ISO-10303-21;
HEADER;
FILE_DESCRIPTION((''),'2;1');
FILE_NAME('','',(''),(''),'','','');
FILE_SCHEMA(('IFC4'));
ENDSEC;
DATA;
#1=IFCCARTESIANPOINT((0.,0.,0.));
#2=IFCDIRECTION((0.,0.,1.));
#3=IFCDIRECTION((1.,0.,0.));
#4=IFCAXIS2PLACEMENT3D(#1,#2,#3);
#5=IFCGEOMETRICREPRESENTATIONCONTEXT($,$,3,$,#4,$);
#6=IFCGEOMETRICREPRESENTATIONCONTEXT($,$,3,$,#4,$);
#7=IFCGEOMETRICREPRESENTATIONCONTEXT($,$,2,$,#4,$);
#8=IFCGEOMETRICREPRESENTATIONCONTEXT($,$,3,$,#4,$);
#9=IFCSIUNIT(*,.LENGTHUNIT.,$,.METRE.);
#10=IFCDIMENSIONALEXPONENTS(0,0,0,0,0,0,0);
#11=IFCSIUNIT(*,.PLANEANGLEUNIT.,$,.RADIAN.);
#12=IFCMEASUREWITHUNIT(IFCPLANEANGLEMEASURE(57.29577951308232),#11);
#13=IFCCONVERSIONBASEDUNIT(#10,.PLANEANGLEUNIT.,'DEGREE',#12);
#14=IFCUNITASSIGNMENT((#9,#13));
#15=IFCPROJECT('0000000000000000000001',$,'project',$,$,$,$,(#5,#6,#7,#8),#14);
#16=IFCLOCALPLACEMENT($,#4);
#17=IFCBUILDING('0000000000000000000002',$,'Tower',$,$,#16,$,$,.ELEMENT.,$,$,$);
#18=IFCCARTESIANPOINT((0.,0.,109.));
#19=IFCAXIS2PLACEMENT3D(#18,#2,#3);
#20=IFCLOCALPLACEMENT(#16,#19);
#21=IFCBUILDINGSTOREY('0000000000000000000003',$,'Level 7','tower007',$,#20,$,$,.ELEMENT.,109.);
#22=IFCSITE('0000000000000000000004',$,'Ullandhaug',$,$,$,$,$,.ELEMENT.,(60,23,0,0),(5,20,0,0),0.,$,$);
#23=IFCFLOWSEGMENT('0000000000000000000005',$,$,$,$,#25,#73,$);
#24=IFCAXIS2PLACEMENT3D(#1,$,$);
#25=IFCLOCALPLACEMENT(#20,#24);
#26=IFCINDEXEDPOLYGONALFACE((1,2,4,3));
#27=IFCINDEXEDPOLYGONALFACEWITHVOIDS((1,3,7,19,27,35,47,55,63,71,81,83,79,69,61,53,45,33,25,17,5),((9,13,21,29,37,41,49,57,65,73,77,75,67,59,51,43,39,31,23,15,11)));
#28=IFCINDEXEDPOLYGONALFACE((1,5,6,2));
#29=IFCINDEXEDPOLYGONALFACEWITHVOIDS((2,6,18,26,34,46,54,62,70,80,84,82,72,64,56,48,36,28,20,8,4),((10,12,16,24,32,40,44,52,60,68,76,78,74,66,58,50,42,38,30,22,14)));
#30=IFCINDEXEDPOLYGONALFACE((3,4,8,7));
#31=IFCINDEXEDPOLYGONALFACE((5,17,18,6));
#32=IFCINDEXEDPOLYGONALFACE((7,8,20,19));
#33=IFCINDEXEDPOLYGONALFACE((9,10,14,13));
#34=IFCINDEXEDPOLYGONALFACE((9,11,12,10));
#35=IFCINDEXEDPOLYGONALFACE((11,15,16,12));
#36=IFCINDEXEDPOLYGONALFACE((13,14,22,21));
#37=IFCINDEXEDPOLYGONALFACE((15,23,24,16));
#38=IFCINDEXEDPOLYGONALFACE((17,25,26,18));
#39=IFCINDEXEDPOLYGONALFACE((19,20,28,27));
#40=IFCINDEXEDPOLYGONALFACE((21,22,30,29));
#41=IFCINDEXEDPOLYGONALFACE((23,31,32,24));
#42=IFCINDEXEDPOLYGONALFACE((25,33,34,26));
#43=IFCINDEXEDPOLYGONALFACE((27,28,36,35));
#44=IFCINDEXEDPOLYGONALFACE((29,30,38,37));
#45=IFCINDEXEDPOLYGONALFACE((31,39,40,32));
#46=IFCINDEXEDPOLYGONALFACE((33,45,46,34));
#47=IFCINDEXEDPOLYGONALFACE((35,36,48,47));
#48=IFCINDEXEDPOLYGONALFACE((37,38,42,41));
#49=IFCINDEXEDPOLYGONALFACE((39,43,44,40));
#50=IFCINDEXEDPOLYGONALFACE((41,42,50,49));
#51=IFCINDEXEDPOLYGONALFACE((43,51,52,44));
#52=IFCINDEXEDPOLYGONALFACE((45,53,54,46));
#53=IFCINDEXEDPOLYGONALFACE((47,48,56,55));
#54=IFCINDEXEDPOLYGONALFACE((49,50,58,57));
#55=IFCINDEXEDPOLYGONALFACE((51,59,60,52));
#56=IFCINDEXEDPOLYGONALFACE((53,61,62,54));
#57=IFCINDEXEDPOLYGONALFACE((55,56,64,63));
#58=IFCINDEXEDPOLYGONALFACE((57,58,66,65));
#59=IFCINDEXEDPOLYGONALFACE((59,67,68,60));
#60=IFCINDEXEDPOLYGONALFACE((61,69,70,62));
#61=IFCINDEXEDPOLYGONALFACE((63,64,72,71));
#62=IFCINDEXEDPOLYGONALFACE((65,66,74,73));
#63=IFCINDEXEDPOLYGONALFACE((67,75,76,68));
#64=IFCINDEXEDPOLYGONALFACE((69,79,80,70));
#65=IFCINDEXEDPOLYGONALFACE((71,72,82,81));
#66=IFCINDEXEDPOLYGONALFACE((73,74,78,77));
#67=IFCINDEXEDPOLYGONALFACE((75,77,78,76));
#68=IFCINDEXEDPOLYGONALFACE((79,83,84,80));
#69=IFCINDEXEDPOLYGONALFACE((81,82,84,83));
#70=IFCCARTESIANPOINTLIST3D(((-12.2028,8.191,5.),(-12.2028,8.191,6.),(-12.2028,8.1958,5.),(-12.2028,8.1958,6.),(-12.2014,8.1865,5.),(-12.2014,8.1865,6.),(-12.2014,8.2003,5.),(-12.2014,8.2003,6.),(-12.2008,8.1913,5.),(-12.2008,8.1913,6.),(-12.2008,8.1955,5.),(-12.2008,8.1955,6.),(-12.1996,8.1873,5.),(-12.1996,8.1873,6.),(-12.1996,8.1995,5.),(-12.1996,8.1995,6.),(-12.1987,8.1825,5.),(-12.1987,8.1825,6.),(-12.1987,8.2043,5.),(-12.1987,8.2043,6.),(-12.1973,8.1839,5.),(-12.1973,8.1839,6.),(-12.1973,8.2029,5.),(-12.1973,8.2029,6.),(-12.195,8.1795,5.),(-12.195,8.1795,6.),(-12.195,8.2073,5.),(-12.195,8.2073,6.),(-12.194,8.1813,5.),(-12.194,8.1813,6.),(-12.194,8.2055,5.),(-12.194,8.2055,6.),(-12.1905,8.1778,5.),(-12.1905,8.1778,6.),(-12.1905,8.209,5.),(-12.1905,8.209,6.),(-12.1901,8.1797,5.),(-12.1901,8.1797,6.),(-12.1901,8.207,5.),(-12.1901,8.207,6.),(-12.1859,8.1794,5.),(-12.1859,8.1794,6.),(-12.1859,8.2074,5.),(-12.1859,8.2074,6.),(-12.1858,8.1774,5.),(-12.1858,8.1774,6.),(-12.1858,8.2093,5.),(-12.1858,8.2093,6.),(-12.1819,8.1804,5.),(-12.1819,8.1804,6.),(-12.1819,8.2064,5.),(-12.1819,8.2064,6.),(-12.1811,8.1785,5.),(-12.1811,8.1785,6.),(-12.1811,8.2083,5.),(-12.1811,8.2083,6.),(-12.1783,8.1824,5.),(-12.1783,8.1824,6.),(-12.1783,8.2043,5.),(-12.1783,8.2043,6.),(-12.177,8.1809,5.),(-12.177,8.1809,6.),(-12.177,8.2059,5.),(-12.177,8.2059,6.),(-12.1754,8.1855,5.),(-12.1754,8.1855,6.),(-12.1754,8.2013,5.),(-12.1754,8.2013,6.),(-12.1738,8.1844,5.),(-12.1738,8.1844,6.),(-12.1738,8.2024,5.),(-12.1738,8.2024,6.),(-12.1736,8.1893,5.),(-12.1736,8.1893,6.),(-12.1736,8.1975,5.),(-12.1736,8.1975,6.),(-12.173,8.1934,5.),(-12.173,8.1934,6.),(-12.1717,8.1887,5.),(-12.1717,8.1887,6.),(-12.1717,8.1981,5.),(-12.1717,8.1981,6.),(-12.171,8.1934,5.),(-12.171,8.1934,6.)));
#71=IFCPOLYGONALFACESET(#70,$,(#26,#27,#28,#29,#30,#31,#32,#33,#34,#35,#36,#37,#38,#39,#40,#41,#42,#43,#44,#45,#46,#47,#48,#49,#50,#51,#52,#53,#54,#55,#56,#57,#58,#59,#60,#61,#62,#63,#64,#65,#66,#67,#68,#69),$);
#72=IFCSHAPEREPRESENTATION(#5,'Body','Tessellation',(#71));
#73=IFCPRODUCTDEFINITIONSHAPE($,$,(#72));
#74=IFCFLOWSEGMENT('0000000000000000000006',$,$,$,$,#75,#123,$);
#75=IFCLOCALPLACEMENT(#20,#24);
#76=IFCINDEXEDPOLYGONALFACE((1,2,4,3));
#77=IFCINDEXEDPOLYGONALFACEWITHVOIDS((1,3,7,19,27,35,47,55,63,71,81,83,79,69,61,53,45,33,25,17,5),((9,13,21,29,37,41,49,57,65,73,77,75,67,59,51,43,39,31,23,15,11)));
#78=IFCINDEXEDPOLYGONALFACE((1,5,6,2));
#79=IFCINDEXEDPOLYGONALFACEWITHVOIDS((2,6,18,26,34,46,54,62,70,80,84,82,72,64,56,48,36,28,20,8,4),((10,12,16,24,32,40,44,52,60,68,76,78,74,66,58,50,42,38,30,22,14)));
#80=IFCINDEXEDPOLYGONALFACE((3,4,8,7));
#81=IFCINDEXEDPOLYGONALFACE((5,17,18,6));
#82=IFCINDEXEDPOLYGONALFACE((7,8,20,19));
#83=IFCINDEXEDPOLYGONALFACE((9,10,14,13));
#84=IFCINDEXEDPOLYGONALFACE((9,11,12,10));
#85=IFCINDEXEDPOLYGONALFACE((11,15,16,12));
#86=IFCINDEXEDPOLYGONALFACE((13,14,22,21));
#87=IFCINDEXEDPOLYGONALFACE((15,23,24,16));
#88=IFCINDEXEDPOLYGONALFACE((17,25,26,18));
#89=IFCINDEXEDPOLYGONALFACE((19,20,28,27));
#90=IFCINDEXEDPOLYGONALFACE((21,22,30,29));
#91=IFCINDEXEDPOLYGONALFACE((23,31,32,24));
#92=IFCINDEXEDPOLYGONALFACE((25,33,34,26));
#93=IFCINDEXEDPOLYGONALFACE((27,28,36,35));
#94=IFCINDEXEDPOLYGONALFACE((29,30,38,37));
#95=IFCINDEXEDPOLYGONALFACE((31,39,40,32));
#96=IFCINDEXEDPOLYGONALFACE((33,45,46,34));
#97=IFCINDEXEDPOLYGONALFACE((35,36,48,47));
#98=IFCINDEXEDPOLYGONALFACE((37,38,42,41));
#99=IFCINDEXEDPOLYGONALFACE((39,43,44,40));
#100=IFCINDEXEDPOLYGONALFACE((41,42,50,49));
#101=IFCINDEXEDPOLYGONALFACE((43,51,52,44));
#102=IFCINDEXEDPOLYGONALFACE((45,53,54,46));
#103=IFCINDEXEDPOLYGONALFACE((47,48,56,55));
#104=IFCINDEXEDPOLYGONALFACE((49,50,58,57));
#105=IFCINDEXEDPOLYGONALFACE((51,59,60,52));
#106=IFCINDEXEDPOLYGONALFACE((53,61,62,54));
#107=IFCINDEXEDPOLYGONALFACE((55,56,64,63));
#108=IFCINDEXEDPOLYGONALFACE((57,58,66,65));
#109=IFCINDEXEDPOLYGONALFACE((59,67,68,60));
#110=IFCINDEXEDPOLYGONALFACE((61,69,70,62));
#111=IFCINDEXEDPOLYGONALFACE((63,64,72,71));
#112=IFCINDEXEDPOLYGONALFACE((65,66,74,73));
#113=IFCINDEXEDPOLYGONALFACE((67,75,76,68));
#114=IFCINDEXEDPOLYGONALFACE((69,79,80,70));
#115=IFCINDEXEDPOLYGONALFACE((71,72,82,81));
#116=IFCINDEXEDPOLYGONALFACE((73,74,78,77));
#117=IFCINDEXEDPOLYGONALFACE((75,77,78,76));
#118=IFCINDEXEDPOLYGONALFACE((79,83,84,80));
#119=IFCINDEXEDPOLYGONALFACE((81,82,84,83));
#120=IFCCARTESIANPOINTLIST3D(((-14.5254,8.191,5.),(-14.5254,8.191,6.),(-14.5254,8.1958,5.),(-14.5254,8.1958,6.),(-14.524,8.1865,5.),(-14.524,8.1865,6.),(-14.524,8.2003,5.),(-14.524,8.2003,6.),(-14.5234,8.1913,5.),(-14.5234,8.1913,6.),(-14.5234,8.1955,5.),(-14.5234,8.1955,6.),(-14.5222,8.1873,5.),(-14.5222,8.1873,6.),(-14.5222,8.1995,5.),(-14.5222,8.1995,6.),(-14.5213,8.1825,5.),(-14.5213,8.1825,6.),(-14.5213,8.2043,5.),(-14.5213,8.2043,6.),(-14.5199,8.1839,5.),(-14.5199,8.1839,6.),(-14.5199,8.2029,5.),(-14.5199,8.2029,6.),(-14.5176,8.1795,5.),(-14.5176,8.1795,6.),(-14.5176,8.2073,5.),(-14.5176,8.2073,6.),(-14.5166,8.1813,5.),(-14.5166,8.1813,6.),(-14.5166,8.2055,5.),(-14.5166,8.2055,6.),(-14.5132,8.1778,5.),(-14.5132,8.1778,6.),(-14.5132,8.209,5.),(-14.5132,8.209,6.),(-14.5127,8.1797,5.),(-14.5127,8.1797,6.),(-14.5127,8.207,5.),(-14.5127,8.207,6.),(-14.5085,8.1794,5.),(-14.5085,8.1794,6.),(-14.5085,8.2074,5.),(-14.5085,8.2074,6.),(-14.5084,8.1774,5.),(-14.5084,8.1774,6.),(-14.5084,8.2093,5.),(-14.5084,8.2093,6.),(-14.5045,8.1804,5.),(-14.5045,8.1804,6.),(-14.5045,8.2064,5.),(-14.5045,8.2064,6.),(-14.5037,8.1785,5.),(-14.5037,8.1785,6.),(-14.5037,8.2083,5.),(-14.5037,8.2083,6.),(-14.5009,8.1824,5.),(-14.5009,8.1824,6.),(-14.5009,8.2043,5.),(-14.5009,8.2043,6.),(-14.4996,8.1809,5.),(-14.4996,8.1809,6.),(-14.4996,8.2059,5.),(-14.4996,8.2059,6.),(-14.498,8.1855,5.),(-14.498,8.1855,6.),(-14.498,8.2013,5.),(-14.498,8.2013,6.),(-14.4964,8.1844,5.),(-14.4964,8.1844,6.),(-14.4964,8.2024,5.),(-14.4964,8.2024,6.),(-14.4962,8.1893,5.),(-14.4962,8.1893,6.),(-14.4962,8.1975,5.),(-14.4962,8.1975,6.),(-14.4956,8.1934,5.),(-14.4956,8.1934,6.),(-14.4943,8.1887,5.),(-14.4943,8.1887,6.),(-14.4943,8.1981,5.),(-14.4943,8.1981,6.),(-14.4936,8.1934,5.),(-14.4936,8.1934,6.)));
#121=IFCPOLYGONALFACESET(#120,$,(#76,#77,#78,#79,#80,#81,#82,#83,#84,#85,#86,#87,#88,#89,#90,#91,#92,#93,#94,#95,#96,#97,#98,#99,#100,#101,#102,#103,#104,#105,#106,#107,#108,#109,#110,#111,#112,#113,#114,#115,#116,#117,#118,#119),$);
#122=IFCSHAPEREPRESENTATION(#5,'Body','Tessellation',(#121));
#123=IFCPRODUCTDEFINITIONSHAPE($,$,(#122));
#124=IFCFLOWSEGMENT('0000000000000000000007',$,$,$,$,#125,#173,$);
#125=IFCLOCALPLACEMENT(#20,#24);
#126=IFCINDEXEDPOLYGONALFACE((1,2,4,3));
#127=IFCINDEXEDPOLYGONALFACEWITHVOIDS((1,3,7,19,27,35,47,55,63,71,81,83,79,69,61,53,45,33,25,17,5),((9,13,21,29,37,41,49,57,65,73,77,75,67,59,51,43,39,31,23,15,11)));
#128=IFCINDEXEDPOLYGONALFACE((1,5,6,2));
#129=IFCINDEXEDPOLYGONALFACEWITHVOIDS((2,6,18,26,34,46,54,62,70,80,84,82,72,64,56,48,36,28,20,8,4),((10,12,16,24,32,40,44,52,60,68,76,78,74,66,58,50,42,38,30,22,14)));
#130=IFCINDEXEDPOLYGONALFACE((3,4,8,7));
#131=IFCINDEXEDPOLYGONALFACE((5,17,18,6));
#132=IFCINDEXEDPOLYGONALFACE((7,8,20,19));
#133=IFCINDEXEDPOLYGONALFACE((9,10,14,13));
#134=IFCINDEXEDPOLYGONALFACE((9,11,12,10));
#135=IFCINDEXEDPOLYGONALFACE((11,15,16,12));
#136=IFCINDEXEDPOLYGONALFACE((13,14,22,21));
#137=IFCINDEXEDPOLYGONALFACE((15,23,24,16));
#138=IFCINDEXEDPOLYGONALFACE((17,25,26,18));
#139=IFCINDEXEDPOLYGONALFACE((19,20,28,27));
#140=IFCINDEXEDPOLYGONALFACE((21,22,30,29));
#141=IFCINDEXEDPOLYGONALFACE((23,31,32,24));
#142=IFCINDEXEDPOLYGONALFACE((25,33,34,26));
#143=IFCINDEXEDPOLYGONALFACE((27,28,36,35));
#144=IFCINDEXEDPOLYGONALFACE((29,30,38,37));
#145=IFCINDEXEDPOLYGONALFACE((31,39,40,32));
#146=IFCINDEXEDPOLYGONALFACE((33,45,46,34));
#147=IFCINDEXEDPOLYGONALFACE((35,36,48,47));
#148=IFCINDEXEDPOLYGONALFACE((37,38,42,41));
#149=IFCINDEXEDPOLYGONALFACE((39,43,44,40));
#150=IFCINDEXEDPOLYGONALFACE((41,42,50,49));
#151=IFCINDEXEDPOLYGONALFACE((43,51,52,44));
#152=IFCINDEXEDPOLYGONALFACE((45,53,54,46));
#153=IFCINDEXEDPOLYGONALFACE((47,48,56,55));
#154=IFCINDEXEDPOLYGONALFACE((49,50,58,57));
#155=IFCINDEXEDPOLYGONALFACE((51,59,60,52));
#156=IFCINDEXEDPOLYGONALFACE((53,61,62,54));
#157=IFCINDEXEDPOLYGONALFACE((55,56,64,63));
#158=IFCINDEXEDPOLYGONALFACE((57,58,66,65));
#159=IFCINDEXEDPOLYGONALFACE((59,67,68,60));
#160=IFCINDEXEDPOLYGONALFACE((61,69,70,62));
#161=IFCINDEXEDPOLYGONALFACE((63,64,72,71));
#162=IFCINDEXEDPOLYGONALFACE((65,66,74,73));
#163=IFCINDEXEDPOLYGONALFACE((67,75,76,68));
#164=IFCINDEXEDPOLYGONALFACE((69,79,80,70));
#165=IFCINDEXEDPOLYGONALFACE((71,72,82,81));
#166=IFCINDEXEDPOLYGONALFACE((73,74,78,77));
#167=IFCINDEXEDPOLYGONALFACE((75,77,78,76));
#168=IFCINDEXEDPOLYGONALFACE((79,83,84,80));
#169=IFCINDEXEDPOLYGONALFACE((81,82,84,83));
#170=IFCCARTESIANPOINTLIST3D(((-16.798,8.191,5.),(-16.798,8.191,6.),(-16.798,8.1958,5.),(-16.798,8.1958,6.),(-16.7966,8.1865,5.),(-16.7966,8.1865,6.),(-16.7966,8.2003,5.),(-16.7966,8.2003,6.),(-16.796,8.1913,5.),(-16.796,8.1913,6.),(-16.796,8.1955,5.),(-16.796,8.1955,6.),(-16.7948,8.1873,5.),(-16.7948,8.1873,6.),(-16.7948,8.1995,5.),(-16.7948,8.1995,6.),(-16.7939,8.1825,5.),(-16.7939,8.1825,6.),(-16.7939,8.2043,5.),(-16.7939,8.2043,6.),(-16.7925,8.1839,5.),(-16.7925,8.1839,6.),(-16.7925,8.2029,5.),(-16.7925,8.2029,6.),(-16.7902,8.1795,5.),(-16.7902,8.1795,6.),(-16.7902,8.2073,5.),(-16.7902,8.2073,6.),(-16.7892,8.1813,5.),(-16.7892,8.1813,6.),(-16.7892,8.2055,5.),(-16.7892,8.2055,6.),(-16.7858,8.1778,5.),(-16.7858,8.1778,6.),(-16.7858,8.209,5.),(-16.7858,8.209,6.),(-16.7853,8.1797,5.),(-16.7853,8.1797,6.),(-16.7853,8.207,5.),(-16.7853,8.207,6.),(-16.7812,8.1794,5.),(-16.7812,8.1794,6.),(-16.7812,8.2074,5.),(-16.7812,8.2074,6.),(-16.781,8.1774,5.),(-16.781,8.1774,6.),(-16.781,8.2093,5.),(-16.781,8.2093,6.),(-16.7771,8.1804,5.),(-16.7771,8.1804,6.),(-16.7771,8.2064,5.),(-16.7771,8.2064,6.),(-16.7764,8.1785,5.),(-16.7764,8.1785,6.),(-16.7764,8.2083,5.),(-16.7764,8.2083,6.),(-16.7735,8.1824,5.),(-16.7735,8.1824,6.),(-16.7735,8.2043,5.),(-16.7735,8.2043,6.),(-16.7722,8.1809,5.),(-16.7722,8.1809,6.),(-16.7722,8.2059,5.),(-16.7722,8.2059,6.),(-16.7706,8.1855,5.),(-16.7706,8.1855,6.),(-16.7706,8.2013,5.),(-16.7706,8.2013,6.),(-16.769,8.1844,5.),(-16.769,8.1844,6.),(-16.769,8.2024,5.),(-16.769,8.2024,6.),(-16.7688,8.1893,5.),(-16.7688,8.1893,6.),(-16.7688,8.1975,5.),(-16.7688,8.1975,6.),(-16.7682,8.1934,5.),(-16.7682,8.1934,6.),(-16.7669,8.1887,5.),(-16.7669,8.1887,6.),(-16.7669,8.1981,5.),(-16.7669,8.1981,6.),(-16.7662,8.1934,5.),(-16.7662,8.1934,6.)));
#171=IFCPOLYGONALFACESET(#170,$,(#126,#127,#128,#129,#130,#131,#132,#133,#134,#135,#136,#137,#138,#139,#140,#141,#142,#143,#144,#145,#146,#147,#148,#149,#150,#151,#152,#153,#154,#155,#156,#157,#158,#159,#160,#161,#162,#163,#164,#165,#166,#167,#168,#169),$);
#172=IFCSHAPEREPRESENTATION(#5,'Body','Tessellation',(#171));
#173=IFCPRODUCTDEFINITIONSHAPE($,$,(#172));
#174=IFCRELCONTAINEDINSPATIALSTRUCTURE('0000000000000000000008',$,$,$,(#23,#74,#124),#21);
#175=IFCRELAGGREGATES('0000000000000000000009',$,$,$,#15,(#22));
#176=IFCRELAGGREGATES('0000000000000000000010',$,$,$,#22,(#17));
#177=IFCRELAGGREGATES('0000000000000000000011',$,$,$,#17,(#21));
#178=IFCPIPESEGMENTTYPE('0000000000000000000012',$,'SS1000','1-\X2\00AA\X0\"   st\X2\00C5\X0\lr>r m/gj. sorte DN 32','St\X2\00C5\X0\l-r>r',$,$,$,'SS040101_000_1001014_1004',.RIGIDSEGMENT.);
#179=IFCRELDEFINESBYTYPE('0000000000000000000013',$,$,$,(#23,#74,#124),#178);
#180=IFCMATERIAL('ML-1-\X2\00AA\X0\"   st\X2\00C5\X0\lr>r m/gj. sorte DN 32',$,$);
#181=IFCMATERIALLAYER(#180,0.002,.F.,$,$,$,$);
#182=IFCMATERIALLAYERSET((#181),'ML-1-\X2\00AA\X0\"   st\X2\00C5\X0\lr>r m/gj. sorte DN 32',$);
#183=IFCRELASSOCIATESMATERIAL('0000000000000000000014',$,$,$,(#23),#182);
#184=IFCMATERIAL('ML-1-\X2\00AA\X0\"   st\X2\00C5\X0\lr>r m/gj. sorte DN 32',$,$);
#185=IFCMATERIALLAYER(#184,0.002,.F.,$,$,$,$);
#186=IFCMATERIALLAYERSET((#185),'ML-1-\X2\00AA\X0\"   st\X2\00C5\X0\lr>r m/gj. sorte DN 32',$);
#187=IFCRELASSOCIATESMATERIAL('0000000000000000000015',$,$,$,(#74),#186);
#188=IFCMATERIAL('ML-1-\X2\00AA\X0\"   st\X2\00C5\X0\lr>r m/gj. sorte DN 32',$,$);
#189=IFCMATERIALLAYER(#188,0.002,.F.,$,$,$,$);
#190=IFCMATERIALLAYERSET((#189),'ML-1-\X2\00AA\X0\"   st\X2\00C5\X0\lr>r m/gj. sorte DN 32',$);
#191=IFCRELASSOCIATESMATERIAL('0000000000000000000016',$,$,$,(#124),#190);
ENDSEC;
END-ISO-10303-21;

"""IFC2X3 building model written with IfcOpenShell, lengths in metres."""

from ifc_helpers import new_model, entity, si_unit, converted_unit, frame, origin_with_axes, origin_2d_with_axis, place, context, project, spatial, hollow_circle, extrude, material, layer, layer_set, layer_usage, type_object, element, save


model = new_model("IFC2X3")

# Units and contexts
context_of_model_1 = context(None, 3, world=origin_with_axes())
context_of_model_2 = context(None, 3, world=origin_with_axes())
context_of_model_3 = context(None, 2, world=origin_with_axes())
context_of_model_4 = context(None, 3, world=origin_with_axes())
ifc_project = project(units=[si_unit("LENGTHUNIT", "METRE"), converted_unit("PLANEANGLEUNIT", "DEGREE", entity("IfcPlaneAngleMeasure", 57.29577951308232), si_unit("PLANEANGLEUNIT", "RADIAN"), dimensions=[0, 0, 0, 0, 0, 0, 0])], contexts=[context_of_model_1, context_of_model_2, context_of_model_3, context_of_model_4])

# Site, building, storey
site = spatial("IfcSite", under=ifc_project, Name="Ullandhaug", CompositionType="ELEMENT", RefLatitude=(60, 23, 0, 0), RefLongitude=(5, 20, 0, 0), RefElevation=0.0)
building_placement = place(None, origin_with_axes())
building = spatial("IfcBuilding", under=site, at=building_placement, Name="Tower", CompositionType="ELEMENT")
storey_placement = place(building_placement, frame((0.0, 0.0, 109.0), z_axis=(0.0, 0.0, 1.0), x_axis=(1.0, 0.0, 0.0)))
storey = spatial("IfcBuildingStorey", under=building, at=storey_placement, Name="Level 7", Description="tower007", CompositionType="ELEMENT", Elevation=109.0)

# Flow segments
ifc_material_1 = material(Name="ML-1-ª\"   stÅlr>r m/gj. sorte DN 32")
ifc_layer_1 = layer(ifc_material_1, 0.002, ventilated=False)
ifc_layer_set_1 = layer_set([ifc_layer_1], Name="ML-1-ª\"   stÅlr>r m/gj. sorte DN 32")
ifc_layer_usage_1 = layer_usage(ifc_layer_set_1, "AXIS2", "POSITIVE", 0.0)
pipe_segment_type_1 = type_object("IfcPipeSegmentType", Name="SS1000", Description="1-ª\"   stÅlr>r m/gj. sorte DN 32", ApplicableOccurrence="StÅl-r>r", ElementType="SS040101_000_1001014_1004", PredefinedType="RIGIDSEGMENT")
flow_segment_1_placement = place(storey_placement, frame((-12.187, 8.1934, 5.0), z_axis=(0.0, 0.0, 1.0), x_axis=(1.0, 0.0, 0.0)))
element("IfcFlowSegment", 1, at=flow_segment_1_placement, inside=storey, type_object=pipe_segment_type_1, material=ifc_layer_usage_1, context=context_of_model_1, shape_type="SweptSolid", body=[
    extrude(hollow_circle(Radius=0.016, WallThickness=0.002, at=origin_2d_with_axis()), origin_with_axes(), (0.0, 0.0, 1.0), 1.0),
])
ifc_material_2 = material(Name="ML-1-ª\"   stÅlr>r m/gj. sorte DN 32")
ifc_layer_2 = layer(ifc_material_2, 0.002, ventilated=False)
ifc_layer_set_2 = layer_set([ifc_layer_2], Name="ML-1-ª\"   stÅlr>r m/gj. sorte DN 32")
ifc_layer_usage_2 = layer_usage(ifc_layer_set_2, "AXIS2", "POSITIVE", 0.0)
flow_segment_2_placement = place(storey_placement, frame((-14.5096, 8.1934, 5.0), z_axis=(0.0, 0.0, 1.0), x_axis=(1.0, 0.0, 0.0)))
element("IfcFlowSegment", 2, at=flow_segment_2_placement, inside=storey, type_object=pipe_segment_type_1, material=ifc_layer_usage_2, context=context_of_model_1, shape_type="SweptSolid", body=[
    extrude(hollow_circle(Radius=0.016, WallThickness=0.002, at=origin_2d_with_axis()), origin_with_axes(), (0.0, 0.0, 1.0), 1.0),
])
ifc_material_3 = material(Name="ML-1-ª\"   stÅlr>r m/gj. sorte DN 32")
ifc_layer_3 = layer(ifc_material_3, 0.002, ventilated=False)
ifc_layer_set_3 = layer_set([ifc_layer_3], Name="ML-1-ª\"   stÅlr>r m/gj. sorte DN 32")
ifc_layer_usage_3 = layer_usage(ifc_layer_set_3, "AXIS2", "POSITIVE", 0.0)
flow_segment_3_placement = place(storey_placement, frame((-16.7822, 8.1934, 5.0), z_axis=(0.0, 0.0, 1.0), x_axis=(1.0, 0.0, 0.0)))
element("IfcFlowSegment", 3, at=flow_segment_3_placement, inside=storey, type_object=pipe_segment_type_1, material=ifc_layer_usage_3, context=context_of_model_1, shape_type="SweptSolid", body=[
    extrude(hollow_circle(Radius=0.016, WallThickness=0.002, at=origin_2d_with_axis()), origin_with_axes(), (0.0, 0.0, 1.0), 1.0),
])

save(model, "model.ifc")
